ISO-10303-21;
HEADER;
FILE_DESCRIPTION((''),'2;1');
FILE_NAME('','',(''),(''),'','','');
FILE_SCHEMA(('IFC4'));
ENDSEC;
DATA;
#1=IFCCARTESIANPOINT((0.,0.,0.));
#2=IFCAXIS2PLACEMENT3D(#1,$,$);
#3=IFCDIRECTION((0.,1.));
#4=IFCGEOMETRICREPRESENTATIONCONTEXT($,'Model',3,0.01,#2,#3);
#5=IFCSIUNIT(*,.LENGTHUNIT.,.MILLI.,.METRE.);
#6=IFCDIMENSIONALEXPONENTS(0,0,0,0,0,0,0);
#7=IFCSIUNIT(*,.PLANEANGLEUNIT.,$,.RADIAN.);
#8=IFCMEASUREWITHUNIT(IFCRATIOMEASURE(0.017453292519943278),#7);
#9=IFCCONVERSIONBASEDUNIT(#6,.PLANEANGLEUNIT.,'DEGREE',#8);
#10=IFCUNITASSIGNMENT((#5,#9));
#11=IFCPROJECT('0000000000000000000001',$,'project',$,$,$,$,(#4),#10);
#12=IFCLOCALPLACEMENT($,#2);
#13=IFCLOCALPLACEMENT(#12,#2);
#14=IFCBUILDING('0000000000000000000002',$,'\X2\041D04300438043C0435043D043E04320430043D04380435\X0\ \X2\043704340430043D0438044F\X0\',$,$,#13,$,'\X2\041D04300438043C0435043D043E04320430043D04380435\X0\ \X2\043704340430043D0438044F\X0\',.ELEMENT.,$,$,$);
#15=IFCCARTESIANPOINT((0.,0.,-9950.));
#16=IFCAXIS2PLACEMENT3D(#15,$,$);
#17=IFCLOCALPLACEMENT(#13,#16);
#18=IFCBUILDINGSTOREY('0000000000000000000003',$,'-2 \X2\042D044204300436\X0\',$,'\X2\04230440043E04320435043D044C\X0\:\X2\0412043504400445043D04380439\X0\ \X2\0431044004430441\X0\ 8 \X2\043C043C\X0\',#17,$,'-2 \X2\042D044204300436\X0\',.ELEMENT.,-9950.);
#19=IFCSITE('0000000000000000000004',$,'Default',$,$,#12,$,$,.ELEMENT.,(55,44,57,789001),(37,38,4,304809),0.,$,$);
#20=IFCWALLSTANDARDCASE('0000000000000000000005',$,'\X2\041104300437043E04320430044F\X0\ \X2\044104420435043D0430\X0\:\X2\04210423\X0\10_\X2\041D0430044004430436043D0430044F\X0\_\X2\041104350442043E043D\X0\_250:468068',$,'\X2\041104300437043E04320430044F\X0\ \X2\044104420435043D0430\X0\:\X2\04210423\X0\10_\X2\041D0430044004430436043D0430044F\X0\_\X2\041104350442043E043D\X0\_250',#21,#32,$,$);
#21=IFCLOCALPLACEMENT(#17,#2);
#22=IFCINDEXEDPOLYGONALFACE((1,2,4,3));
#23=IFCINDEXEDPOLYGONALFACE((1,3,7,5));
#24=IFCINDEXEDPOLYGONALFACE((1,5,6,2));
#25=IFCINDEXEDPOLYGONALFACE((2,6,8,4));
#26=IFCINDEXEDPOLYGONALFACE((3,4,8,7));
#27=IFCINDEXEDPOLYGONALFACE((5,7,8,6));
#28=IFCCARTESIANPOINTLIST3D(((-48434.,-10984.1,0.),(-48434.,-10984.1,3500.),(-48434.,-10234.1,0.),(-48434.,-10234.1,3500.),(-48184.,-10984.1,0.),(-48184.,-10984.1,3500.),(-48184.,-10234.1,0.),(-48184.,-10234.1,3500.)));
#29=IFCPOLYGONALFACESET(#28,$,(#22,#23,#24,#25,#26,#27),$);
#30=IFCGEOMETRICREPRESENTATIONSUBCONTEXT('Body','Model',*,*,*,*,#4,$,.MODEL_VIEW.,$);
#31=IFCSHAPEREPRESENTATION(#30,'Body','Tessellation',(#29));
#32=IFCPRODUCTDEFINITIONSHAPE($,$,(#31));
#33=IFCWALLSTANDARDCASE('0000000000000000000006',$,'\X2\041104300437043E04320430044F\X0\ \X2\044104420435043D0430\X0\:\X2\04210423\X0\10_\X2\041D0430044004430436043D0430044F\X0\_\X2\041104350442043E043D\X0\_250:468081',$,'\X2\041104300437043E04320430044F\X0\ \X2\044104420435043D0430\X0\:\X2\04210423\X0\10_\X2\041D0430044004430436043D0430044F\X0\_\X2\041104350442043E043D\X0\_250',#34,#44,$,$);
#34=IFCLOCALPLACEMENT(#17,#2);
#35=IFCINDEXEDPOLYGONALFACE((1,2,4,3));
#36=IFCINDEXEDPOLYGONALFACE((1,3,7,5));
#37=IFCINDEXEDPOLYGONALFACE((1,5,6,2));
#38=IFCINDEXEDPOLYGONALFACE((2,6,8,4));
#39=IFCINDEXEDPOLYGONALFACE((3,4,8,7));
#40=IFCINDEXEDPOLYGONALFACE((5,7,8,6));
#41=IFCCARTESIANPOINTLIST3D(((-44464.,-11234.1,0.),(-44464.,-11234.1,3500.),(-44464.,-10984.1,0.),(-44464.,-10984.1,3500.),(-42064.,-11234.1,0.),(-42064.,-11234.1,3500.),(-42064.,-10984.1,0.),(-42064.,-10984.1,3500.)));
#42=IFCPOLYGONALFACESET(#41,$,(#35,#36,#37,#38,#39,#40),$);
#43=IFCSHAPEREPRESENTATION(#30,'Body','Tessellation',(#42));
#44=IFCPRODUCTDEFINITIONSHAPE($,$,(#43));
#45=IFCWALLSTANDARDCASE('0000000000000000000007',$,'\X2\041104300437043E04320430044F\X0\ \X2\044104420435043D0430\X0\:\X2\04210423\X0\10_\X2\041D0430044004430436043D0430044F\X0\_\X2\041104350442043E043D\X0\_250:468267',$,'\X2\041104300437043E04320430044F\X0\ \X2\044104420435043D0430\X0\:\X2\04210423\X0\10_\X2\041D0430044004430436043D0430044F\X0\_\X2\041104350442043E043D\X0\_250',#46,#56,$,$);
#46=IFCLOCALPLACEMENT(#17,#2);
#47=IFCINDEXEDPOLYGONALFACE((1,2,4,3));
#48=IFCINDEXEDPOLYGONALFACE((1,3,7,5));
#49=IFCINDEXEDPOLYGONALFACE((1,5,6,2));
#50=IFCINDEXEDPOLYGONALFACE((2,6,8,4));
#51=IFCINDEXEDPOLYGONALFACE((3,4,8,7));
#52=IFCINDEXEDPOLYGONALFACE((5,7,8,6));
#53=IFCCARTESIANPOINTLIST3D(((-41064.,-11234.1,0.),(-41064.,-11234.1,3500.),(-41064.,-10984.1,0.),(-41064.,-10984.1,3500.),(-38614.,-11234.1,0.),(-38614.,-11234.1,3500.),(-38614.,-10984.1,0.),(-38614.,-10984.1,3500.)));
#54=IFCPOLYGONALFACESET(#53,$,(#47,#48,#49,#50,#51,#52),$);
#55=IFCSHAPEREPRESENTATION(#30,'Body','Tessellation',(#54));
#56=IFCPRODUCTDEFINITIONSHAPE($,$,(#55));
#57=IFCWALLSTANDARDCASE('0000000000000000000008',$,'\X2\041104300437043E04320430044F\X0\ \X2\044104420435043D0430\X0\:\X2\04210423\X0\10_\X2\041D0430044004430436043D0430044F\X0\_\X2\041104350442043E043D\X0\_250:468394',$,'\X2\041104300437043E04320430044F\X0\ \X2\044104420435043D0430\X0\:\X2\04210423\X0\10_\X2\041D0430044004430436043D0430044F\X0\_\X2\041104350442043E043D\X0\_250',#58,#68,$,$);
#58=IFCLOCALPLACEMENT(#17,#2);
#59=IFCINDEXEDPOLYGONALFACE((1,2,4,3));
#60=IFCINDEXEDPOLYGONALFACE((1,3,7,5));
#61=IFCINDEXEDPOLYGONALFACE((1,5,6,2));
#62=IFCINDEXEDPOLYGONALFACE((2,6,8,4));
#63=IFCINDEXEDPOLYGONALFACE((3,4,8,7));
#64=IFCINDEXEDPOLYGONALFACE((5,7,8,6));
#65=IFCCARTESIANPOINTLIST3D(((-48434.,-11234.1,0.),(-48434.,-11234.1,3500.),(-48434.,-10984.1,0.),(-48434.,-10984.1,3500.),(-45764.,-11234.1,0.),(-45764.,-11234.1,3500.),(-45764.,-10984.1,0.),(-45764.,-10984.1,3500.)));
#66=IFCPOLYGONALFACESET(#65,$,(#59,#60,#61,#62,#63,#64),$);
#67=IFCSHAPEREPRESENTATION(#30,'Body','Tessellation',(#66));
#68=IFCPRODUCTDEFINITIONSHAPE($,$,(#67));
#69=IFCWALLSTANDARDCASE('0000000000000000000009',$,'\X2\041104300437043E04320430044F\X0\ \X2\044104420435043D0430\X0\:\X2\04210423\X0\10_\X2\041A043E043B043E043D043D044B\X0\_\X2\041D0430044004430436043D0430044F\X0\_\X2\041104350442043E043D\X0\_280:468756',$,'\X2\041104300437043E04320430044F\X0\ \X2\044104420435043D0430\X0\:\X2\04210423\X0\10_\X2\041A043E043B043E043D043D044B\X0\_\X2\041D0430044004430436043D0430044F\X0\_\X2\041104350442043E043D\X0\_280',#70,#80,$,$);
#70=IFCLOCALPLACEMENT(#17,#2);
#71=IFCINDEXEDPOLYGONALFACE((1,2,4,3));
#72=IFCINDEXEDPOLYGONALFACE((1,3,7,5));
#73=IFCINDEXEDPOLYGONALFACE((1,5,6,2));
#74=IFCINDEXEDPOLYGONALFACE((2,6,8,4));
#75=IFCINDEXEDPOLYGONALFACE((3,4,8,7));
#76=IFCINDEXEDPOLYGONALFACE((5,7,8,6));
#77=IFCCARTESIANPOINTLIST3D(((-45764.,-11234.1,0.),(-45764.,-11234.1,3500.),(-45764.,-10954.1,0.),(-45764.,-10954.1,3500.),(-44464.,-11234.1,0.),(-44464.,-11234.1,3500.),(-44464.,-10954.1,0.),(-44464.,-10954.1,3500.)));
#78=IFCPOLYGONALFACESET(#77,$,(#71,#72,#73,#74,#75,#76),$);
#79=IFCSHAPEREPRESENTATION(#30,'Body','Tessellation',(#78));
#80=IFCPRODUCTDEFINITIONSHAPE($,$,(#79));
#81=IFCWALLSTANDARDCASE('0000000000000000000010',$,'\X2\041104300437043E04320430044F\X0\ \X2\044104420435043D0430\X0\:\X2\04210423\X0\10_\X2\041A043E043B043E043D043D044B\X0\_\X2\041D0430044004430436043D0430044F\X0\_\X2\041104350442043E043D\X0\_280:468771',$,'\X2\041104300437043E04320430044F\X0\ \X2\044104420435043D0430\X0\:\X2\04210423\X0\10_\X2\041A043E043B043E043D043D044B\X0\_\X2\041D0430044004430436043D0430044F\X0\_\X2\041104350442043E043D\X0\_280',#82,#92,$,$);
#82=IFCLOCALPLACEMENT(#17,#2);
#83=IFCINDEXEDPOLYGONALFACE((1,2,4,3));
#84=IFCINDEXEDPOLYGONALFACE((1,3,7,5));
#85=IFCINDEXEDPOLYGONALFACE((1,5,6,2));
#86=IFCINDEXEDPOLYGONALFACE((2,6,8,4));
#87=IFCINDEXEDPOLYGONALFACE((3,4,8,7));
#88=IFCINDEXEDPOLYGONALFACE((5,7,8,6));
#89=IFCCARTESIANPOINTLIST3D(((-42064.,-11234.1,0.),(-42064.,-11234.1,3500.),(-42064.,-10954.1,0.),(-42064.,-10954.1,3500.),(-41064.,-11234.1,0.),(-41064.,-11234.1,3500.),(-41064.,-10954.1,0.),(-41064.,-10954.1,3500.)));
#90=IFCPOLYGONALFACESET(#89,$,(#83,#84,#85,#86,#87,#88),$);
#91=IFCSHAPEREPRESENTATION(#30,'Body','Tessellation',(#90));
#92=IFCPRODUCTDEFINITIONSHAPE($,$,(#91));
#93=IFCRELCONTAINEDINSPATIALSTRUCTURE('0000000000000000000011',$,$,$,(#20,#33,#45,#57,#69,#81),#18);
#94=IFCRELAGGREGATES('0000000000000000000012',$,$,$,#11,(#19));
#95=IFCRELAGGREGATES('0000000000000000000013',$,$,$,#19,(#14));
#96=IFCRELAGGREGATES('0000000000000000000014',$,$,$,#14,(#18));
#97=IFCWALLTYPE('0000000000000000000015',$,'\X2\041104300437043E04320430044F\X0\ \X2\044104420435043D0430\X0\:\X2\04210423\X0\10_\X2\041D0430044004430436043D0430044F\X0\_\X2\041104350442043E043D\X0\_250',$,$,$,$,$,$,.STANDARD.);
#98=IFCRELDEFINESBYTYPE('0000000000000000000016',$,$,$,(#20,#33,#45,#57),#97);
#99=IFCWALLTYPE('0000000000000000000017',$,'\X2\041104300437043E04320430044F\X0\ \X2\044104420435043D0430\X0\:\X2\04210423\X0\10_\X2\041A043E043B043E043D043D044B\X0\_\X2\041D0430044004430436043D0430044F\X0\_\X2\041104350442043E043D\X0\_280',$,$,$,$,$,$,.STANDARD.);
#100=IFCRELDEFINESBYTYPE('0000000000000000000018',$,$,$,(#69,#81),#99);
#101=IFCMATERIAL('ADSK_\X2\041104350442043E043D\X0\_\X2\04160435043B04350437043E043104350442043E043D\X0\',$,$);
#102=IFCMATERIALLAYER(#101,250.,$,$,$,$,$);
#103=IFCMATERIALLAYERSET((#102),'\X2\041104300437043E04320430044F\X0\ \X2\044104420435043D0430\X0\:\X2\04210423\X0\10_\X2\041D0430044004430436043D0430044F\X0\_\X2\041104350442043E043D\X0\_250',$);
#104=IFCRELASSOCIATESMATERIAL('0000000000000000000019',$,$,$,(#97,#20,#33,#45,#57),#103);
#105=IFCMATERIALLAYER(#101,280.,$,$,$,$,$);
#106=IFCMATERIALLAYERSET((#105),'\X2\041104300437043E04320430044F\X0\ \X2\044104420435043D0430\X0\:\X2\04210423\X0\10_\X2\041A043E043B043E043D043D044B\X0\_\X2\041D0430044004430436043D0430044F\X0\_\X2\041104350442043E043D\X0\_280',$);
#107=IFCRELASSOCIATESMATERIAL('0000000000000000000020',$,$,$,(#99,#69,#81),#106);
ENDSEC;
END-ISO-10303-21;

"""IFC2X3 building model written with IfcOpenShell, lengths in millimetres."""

from ifc_helpers import new_model, entity, si_unit, converted_unit, direction, frame, frame_2d, origin, place, context, subcontext, project, spatial, rectangle, extrude, material, layer, layer_set, layer_usage, type_object, element, save


model = new_model("IFC2X3")

# Units and contexts
model_context = context("Model", 3, precision=0.01, world=origin(), true_north=direction((0.0, 1.0)))
body_context = subcontext(model_context, "Body", "Model", "MODEL_VIEW")
ifc_project = project(units=[si_unit("LENGTHUNIT", "METRE", prefix="MILLI"), converted_unit("PLANEANGLEUNIT", "DEGREE", entity("IfcRatioMeasure", 0.017453292519943278), si_unit("PLANEANGLEUNIT", "RADIAN"), dimensions=[0, 0, 0, 0, 0, 0, 0])], contexts=[model_context])

# Site, building, storey
site_placement = place(None, origin())
site = spatial("IfcSite", under=ifc_project, at=site_placement, Name="Default", CompositionType="ELEMENT", RefLatitude=(55, 44, 57, 789001), RefLongitude=(37, 38, 4, 304809), RefElevation=0.0)
building_placement = place(site_placement, origin())
building = spatial("IfcBuilding", under=site, at=building_placement, Name="Наименование здания", LongName="Наименование здания", CompositionType="ELEMENT")
storey_placement = place(building_placement, frame((0.0, 0.0, -9950.0)))
storey = spatial("IfcBuildingStorey", under=building, at=storey_placement, Name="-2 Этаж", ObjectType="Уровень:Верхний брус 8 мм", LongName="-2 Этаж", CompositionType="ELEMENT", Elevation=-9950.0)

# Shared definitions
ifc_material = material(Name="ADSK_Бетон_Железобетон")

# Walls
ifc_layer_1 = layer(ifc_material, 250.0)
ifc_layer_set_1 = layer_set([ifc_layer_1], Name="Базовая стена:СУ10_Наружная_Бетон_250")
ifc_layer_usage_1 = layer_usage(ifc_layer_set_1, "AXIS2", "NEGATIVE", 125.0)
wall_type_1 = type_object("IfcWallType", Name="Базовая стена:СУ10_Наружная_Бетон_250", PredefinedType="STANDARD", material=ifc_layer_set_1)
wall_1_placement = place(storey_placement, frame((-48309.0, -10984.1, 0.0), z_axis=(0.0, 0.0, 1.0), x_axis=(0.0, 1.0, 0.0)))
element("IfcWallStandardCase", 1, at=wall_1_placement, inside=storey, type_object=wall_type_1, material=ifc_layer_usage_1, Name="Базовая стена:СУ10_Наружная_Бетон_250:468068", ObjectType="Базовая стена:СУ10_Наружная_Бетон_250", context=body_context, shape_type="SweptSolid", body=[
    extrude(rectangle(XDim=750.0, YDim=250.0, at=frame_2d((375.0, 0.0), x_axis=(-1.0, 0.0))), origin(), (0.0, 0.0, 1.0), 3500.0),
])
wall_2_placement = place(storey_placement, frame((-44464.0, -11109.1, 0.0)))
element("IfcWallStandardCase", 2, at=wall_2_placement, inside=storey, type_object=wall_type_1, material=ifc_layer_usage_1, Name="Базовая стена:СУ10_Наружная_Бетон_250:468081", ObjectType="Базовая стена:СУ10_Наружная_Бетон_250", context=body_context, shape_type="SweptSolid", body=[
    extrude(rectangle(XDim=2400.0, YDim=250.0, at=frame_2d((1200.0, 0.0), x_axis=(-1.0, 0.0))), origin(), (0.0, 0.0, 1.0), 3500.0),
])
wall_3_placement = place(storey_placement, frame((-41064.0, -11109.1, 0.0)))
element("IfcWallStandardCase", 3, at=wall_3_placement, inside=storey, type_object=wall_type_1, material=ifc_layer_usage_1, Name="Базовая стена:СУ10_Наружная_Бетон_250:468267", ObjectType="Базовая стена:СУ10_Наружная_Бетон_250", context=body_context, shape_type="SweptSolid", body=[
    extrude(rectangle(XDim=2450.0, YDim=250.0, at=frame_2d((1225.0, 0.0), x_axis=(-1.0, 0.0))), origin(), (0.0, 0.0, 1.0), 3500.0),
])
wall_4_placement = place(storey_placement, frame((-48434.0, -11109.1, 0.0)))
element("IfcWallStandardCase", 4, at=wall_4_placement, inside=storey, type_object=wall_type_1, material=ifc_layer_usage_1, Name="Базовая стена:СУ10_Наружная_Бетон_250:468394", ObjectType="Базовая стена:СУ10_Наружная_Бетон_250", context=body_context, shape_type="SweptSolid", body=[
    extrude(rectangle(XDim=2670.0, YDim=250.0, at=frame_2d((1335.0, 0.0), x_axis=(-1.0, 0.0))), origin(), (0.0, 0.0, 1.0), 3500.0),
])
ifc_layer_2 = layer(ifc_material, 280.0)
ifc_layer_set_2 = layer_set([ifc_layer_2], Name="Базовая стена:СУ10_Колонны_Наружная_Бетон_280")
ifc_layer_usage_2 = layer_usage(ifc_layer_set_2, "AXIS2", "NEGATIVE", 140.0)
wall_type_2 = type_object("IfcWallType", Name="Базовая стена:СУ10_Колонны_Наружная_Бетон_280", PredefinedType="STANDARD", material=ifc_layer_set_2)
wall_5_placement = place(storey_placement, frame((-45764.0, -11094.1, 0.0)))
element("IfcWallStandardCase", 5, at=wall_5_placement, inside=storey, type_object=wall_type_2, material=ifc_layer_usage_2, Name="Базовая стена:СУ10_Колонны_Наружная_Бетон_280:468756", ObjectType="Базовая стена:СУ10_Колонны_Наружная_Бетон_280", context=body_context, shape_type="SweptSolid", body=[
    extrude(rectangle(XDim=1300.0, YDim=280.0, at=frame_2d((650.0, 0.0), x_axis=(-1.0, 0.0))), origin(), (0.0, 0.0, 1.0), 3500.0),
])
wall_6_placement = place(storey_placement, frame((-42064.0, -11094.1, 0.0)))
element("IfcWallStandardCase", 6, at=wall_6_placement, inside=storey, type_object=wall_type_2, material=ifc_layer_usage_2, Name="Базовая стена:СУ10_Колонны_Наружная_Бетон_280:468771", ObjectType="Базовая стена:СУ10_Колонны_Наружная_Бетон_280", context=body_context, shape_type="SweptSolid", body=[
    extrude(rectangle(XDim=1000.0, YDim=280.0, at=frame_2d((500.0, 0.0), x_axis=(-1.0, 0.0))), origin(), (0.0, 0.0, 1.0), 3500.0),
])

save(model, "model.ifc")
